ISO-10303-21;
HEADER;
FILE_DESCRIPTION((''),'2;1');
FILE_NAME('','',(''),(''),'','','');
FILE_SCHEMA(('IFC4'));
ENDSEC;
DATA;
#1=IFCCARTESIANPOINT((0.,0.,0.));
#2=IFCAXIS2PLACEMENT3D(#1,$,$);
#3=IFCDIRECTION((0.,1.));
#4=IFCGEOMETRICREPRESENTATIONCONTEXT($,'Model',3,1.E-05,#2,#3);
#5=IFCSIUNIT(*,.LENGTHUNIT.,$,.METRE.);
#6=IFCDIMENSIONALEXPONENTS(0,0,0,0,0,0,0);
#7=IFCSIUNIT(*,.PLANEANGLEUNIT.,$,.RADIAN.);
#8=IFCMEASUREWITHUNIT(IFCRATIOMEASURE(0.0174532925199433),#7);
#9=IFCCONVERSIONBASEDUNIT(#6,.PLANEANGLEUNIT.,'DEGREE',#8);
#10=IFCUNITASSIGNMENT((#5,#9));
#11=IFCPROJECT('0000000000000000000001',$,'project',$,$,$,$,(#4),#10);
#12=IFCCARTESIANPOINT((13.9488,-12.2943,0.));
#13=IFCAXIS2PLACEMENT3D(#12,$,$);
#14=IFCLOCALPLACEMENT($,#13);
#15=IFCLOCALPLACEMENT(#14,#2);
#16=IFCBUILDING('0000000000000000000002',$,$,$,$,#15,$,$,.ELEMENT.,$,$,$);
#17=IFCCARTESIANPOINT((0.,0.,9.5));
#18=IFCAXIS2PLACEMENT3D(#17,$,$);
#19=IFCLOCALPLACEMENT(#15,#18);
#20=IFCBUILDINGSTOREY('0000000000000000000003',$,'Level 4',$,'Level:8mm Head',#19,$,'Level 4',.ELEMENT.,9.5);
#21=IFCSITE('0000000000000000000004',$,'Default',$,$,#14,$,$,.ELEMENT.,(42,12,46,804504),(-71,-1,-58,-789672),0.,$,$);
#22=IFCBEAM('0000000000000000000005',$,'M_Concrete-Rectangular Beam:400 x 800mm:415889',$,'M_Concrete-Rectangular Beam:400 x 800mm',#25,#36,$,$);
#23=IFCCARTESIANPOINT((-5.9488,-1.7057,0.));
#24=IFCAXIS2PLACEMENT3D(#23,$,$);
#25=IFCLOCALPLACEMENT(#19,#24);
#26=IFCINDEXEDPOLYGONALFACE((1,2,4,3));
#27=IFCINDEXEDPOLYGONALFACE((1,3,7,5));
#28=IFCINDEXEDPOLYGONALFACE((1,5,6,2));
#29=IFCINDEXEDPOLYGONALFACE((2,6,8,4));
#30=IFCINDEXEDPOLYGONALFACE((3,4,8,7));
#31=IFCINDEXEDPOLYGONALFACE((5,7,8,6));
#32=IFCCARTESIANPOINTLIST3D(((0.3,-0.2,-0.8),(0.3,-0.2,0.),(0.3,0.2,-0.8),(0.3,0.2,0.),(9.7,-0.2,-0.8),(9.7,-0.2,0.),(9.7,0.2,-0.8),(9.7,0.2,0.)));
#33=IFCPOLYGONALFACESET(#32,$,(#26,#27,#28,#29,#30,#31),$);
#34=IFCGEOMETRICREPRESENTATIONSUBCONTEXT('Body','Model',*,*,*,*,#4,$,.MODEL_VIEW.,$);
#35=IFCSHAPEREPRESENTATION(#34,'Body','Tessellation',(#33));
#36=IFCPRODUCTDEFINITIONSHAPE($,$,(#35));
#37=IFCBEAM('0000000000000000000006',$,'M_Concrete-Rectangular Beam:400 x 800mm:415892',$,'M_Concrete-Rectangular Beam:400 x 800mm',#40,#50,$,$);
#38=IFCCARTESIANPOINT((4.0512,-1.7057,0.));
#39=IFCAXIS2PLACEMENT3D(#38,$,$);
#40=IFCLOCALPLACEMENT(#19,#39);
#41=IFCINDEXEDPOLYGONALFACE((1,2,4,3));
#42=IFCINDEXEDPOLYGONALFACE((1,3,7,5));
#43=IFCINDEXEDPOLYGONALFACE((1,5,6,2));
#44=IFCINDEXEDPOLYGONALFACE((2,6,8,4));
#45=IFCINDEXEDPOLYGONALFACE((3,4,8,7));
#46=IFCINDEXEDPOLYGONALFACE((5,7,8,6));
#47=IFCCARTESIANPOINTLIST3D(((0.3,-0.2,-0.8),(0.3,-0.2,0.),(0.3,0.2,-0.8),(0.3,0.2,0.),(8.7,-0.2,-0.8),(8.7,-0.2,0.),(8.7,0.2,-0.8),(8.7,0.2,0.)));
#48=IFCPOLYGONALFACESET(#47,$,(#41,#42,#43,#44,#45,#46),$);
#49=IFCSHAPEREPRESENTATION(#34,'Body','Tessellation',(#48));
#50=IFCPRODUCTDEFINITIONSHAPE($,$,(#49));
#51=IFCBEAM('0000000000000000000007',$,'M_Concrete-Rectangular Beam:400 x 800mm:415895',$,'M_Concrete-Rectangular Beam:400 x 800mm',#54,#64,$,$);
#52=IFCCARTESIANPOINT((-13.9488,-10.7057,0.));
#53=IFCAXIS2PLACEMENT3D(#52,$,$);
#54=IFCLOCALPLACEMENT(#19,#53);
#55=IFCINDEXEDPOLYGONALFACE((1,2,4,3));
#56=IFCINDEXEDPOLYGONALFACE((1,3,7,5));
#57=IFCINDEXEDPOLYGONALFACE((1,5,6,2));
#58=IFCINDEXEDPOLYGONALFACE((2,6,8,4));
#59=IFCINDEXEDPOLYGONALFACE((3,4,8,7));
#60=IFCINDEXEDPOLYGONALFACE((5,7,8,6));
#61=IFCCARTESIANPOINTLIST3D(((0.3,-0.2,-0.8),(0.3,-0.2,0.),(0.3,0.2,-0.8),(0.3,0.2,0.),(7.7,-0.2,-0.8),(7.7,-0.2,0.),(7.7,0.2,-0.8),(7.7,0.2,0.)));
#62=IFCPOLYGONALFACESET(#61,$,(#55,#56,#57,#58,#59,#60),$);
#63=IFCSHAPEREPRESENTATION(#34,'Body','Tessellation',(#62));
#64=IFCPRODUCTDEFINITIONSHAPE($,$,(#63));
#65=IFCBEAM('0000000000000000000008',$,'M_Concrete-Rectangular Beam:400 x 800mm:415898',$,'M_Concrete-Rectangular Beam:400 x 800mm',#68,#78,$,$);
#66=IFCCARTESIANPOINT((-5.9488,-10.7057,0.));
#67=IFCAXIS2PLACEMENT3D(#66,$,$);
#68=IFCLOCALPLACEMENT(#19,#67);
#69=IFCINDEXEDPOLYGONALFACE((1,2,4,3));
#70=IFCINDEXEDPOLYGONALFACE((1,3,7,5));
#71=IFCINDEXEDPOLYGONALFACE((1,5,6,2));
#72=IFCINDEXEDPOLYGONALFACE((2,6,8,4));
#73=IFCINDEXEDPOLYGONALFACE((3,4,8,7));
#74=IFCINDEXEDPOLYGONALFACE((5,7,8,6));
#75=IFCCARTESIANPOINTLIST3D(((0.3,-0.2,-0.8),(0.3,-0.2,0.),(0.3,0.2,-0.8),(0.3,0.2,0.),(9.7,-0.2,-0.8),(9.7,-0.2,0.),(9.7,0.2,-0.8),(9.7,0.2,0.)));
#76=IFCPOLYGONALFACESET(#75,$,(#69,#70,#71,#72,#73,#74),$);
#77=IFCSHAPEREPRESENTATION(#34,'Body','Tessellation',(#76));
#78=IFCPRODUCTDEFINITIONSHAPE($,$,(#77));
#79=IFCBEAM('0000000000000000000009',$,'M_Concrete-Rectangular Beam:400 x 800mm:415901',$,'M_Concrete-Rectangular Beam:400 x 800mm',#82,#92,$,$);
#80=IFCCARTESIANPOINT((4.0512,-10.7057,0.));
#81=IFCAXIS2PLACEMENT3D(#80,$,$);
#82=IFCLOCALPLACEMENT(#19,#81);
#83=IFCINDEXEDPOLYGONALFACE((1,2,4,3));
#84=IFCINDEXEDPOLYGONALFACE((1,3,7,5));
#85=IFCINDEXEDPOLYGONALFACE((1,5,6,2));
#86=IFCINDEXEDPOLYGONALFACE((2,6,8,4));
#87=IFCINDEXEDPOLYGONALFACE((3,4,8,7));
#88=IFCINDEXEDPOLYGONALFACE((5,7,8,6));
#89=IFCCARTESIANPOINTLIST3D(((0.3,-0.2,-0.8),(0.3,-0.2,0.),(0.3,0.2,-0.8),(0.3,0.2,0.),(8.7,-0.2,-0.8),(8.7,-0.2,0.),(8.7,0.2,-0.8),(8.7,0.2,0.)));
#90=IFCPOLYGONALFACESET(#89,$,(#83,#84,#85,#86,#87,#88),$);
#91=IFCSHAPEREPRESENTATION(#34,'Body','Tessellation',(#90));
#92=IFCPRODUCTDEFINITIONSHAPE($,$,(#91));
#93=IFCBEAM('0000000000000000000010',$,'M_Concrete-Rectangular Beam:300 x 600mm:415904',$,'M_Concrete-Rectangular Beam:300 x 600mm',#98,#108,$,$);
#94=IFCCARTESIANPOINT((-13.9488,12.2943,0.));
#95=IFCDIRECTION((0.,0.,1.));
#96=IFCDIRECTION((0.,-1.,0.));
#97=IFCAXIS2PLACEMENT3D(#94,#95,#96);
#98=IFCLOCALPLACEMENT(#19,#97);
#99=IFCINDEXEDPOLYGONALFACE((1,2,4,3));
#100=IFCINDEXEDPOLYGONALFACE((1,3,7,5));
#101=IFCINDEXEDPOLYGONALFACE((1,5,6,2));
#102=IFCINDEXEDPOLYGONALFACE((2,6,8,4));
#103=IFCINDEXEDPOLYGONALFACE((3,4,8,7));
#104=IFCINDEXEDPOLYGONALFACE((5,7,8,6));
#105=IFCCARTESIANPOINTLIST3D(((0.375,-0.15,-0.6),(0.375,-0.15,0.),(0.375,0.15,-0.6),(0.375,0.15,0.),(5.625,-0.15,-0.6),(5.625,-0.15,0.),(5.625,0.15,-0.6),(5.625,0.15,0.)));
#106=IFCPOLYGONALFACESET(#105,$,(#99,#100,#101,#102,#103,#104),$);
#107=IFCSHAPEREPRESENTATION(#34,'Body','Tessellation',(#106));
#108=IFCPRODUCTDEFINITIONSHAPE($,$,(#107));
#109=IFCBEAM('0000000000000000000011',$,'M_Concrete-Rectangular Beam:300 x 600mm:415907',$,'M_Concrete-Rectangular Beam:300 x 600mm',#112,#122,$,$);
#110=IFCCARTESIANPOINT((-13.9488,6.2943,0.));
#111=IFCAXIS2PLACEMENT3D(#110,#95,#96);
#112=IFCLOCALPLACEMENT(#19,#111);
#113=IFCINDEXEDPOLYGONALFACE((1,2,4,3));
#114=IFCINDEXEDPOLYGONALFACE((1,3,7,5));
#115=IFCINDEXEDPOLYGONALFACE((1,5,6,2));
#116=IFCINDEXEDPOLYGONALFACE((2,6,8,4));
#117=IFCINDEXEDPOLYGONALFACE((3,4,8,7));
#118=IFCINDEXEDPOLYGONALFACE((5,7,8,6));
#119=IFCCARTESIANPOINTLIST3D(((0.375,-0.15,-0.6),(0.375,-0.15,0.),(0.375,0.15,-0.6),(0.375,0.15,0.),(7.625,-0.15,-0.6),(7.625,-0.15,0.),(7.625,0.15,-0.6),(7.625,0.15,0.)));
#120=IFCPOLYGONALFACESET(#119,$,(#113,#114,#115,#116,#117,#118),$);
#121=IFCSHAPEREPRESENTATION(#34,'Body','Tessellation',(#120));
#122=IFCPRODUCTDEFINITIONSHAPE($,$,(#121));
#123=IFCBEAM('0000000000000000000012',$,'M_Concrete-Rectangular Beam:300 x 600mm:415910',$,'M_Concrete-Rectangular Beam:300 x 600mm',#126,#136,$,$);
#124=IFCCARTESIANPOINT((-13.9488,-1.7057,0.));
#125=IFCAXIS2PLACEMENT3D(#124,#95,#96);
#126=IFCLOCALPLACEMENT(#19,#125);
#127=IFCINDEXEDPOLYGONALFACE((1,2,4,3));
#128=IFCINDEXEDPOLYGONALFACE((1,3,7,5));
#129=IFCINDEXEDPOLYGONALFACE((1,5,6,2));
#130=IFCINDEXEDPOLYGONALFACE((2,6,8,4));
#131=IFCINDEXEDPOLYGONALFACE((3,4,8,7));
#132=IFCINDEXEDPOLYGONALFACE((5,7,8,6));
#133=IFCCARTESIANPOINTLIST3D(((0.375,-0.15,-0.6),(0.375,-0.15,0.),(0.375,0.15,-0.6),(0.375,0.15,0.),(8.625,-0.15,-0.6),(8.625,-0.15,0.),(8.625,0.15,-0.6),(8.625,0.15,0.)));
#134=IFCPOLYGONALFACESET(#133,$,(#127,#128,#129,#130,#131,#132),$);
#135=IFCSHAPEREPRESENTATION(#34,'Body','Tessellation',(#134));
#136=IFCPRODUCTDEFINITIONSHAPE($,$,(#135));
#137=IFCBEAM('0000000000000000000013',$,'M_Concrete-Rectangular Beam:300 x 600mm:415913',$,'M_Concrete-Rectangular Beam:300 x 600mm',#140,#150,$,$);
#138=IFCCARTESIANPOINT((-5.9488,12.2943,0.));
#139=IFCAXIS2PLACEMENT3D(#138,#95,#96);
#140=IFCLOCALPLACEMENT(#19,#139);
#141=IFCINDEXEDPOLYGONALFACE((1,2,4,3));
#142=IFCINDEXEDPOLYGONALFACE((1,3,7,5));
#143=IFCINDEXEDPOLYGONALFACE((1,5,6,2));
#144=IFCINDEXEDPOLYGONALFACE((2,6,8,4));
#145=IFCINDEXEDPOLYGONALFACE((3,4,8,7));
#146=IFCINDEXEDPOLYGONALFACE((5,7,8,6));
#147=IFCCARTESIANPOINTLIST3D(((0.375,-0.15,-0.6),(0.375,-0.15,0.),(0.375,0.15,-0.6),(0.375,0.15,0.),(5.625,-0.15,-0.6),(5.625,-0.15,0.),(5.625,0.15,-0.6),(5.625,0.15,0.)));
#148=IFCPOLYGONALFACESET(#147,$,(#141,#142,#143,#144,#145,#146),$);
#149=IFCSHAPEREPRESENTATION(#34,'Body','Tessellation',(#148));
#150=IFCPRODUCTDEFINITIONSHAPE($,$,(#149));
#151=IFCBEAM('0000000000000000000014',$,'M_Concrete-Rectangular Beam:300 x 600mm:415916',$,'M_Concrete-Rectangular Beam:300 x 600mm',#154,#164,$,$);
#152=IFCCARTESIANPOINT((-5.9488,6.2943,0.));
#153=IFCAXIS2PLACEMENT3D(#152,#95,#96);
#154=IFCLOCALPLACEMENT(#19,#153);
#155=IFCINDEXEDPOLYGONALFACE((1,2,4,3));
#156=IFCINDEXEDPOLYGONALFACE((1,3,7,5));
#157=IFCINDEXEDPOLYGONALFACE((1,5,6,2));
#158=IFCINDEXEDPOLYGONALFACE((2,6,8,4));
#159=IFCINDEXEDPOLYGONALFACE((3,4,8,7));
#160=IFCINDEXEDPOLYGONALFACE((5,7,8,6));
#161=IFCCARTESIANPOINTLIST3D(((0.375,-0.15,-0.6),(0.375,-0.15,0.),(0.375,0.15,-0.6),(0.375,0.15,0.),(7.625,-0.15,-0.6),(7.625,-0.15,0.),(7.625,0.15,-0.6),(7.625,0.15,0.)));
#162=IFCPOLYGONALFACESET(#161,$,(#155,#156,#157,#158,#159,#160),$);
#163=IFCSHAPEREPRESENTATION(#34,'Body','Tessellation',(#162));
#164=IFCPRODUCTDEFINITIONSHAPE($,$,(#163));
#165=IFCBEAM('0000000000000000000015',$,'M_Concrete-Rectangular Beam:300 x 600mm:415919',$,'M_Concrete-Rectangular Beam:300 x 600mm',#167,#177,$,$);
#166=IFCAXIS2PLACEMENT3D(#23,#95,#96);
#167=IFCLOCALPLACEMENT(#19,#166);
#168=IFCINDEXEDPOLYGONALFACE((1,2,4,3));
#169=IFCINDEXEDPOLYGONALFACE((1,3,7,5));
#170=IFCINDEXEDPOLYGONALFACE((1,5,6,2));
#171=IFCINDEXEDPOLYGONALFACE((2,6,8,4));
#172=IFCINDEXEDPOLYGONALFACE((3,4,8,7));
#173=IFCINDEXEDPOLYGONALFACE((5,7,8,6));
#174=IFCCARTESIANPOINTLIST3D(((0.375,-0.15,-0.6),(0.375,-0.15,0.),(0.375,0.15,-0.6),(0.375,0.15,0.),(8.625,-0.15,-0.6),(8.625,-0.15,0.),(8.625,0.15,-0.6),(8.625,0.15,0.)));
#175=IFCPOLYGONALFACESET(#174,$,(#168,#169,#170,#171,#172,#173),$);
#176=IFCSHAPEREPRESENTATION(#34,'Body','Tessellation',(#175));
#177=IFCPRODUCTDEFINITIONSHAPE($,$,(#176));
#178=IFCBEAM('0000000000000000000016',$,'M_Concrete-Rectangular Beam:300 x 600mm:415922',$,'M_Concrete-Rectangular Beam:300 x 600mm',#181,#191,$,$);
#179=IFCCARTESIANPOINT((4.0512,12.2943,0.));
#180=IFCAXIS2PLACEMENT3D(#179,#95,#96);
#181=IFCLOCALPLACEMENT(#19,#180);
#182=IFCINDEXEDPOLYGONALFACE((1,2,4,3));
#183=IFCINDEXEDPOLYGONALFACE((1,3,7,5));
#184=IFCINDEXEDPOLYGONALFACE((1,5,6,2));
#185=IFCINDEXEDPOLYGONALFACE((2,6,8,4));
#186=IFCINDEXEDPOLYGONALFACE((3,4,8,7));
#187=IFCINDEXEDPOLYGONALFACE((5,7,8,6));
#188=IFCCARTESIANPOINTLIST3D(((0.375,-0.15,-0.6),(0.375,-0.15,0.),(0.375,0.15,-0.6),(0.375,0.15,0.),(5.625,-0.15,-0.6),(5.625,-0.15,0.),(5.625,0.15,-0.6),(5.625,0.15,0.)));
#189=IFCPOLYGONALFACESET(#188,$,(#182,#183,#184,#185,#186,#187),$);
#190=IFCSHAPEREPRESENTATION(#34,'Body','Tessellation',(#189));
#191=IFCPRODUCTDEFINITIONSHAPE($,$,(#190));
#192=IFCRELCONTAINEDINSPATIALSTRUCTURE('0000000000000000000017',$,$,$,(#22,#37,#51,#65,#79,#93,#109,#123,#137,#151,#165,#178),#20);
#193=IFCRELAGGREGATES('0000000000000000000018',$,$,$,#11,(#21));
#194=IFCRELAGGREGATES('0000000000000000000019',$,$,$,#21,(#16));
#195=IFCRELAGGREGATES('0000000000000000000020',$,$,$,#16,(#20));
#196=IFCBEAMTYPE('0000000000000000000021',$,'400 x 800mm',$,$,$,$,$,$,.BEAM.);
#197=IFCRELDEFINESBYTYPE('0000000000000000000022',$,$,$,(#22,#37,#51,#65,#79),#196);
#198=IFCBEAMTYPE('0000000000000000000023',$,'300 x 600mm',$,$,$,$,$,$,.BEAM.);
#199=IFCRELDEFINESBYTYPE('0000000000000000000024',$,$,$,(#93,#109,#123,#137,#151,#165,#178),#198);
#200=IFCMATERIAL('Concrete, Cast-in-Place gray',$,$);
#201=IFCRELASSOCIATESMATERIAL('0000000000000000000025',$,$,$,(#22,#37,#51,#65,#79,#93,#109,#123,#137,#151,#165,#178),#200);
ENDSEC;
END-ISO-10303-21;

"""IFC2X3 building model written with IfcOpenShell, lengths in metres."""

from ifc_helpers import new_model, entity, si_unit, converted_unit, direction, frame, frame_2d, origin, place, context, subcontext, project, spatial, rectangle, extrude, material, type_object, element, save


model = new_model("IFC2X3")

# Units and contexts
model_context = context("Model", 3, precision=1e-05, world=origin(), true_north=direction((0.0, 1.0)))
body_context = subcontext(model_context, "Body", "Model", "MODEL_VIEW")
ifc_project = project(units=[si_unit("LENGTHUNIT", "METRE"), converted_unit("PLANEANGLEUNIT", "DEGREE", entity("IfcRatioMeasure", 0.0174532925199433), si_unit("PLANEANGLEUNIT", "RADIAN"), dimensions=[0, 0, 0, 0, 0, 0, 0])], contexts=[model_context])

# Site, building, storey
site_placement = place(None, frame((13.9488, -12.2943, 0.0)))
site = spatial("IfcSite", under=ifc_project, at=site_placement, Name="Default", CompositionType="ELEMENT", RefLatitude=(42, 12, 46, 804504), RefLongitude=(-71, -1, -58, -789672), RefElevation=0.0)
building_placement = place(site_placement, origin())
building = spatial("IfcBuilding", under=site, at=building_placement, CompositionType="ELEMENT")
storey_placement = place(building_placement, frame((0.0, 0.0, 9.5)))
storey = spatial("IfcBuildingStorey", under=building, at=storey_placement, Name="Level 4", ObjectType="Level:8mm Head", LongName="Level 4", CompositionType="ELEMENT", Elevation=9.5)

# Shared definitions
ifc_material = material(Name="Concrete, Cast-in-Place gray")

# Beams
beam_type_1 = type_object("IfcBeamType", Name="400 x 800mm", PredefinedType="BEAM")
beam_1_placement = place(storey_placement, frame((-5.9488, -1.7057, 0.0)))
element("IfcBeam", 1, at=beam_1_placement, inside=storey, type_object=beam_type_1, material=ifc_material, Name="M_Concrete-Rectangular Beam:400 x 800mm:415889", ObjectType="M_Concrete-Rectangular Beam:400 x 800mm", context=body_context, shape_type="SweptSolid", body=[
    extrude(rectangle(XDim=0.8, YDim=0.4, at=frame_2d((0.0, 0.0), x_axis=(1.0, 0.0))), frame((0.3, 0.0, -0.4), z_axis=(1.0, 0.0, 0.0), x_axis=(0.0, 0.0, -1.0)), (0.0, 0.0, 1.0), 9.4),
])
beam_2_placement = place(storey_placement, frame((4.0512, -1.7057, 0.0)))
element("IfcBeam", 2, at=beam_2_placement, inside=storey, type_object=beam_type_1, material=ifc_material, Name="M_Concrete-Rectangular Beam:400 x 800mm:415892", ObjectType="M_Concrete-Rectangular Beam:400 x 800mm", context=body_context, shape_type="SweptSolid", body=[
    extrude(rectangle(XDim=0.8, YDim=0.4, at=frame_2d((0.0, 0.0), x_axis=(1.0, 0.0))), frame((0.3, 0.0, -0.4), z_axis=(1.0, 0.0, 0.0), x_axis=(0.0, 0.0, -1.0)), (0.0, 0.0, 1.0), 8.4),
])
beam_3_placement = place(storey_placement, frame((-13.9488, -10.7057, 0.0)))
element("IfcBeam", 3, at=beam_3_placement, inside=storey, type_object=beam_type_1, material=ifc_material, Name="M_Concrete-Rectangular Beam:400 x 800mm:415895", ObjectType="M_Concrete-Rectangular Beam:400 x 800mm", context=body_context, shape_type="SweptSolid", body=[
    extrude(rectangle(XDim=0.8, YDim=0.4, at=frame_2d((0.0, 0.0), x_axis=(1.0, 0.0))), frame((0.3, 0.0, -0.4), z_axis=(1.0, 0.0, 0.0), x_axis=(0.0, 0.0, -1.0)), (0.0, 0.0, 1.0), 7.4),
])
beam_4_placement = place(storey_placement, frame((-5.9488, -10.7057, 0.0)))
element("IfcBeam", 4, at=beam_4_placement, inside=storey, type_object=beam_type_1, material=ifc_material, Name="M_Concrete-Rectangular Beam:400 x 800mm:415898", ObjectType="M_Concrete-Rectangular Beam:400 x 800mm", context=body_context, shape_type="SweptSolid", body=[
    extrude(rectangle(XDim=0.8, YDim=0.4, at=frame_2d((0.0, 0.0), x_axis=(1.0, 0.0))), frame((0.3, 0.0, -0.4), z_axis=(1.0, 0.0, 0.0), x_axis=(0.0, 0.0, -1.0)), (0.0, 0.0, 1.0), 9.4),
])
beam_5_placement = place(storey_placement, frame((4.0512, -10.7057, 0.0)))
element("IfcBeam", 5, at=beam_5_placement, inside=storey, type_object=beam_type_1, material=ifc_material, Name="M_Concrete-Rectangular Beam:400 x 800mm:415901", ObjectType="M_Concrete-Rectangular Beam:400 x 800mm", context=body_context, shape_type="SweptSolid", body=[
    extrude(rectangle(XDim=0.8, YDim=0.4, at=frame_2d((0.0, 0.0), x_axis=(1.0, 0.0))), frame((0.3, 0.0, -0.4), z_axis=(1.0, 0.0, 0.0), x_axis=(0.0, 0.0, -1.0)), (0.0, 0.0, 1.0), 8.4),
])
beam_type_2 = type_object("IfcBeamType", Name="300 x 600mm", PredefinedType="BEAM")
beam_6_placement = place(storey_placement, frame((-13.9488, 12.2943, 0.0), z_axis=(0.0, 0.0, 1.0), x_axis=(0.0, -1.0, 0.0)))
element("IfcBeam", 6, at=beam_6_placement, inside=storey, type_object=beam_type_2, material=ifc_material, Name="M_Concrete-Rectangular Beam:300 x 600mm:415904", ObjectType="M_Concrete-Rectangular Beam:300 x 600mm", context=body_context, shape_type="SweptSolid", body=[
    extrude(rectangle(XDim=0.6, YDim=0.3, at=frame_2d((0.0, 0.0), x_axis=(1.0, 0.0))), frame((0.375, 0.0, -0.3), z_axis=(1.0, 0.0, 0.0), x_axis=(0.0, 0.0, -1.0)), (0.0, 0.0, 1.0), 5.25),
])
beam_7_placement = place(storey_placement, frame((-13.9488, 6.2943, 0.0), z_axis=(0.0, 0.0, 1.0), x_axis=(0.0, -1.0, 0.0)))
element("IfcBeam", 7, at=beam_7_placement, inside=storey, type_object=beam_type_2, material=ifc_material, Name="M_Concrete-Rectangular Beam:300 x 600mm:415907", ObjectType="M_Concrete-Rectangular Beam:300 x 600mm", context=body_context, shape_type="SweptSolid", body=[
    extrude(rectangle(XDim=0.6, YDim=0.3, at=frame_2d((0.0, 0.0), x_axis=(1.0, 0.0))), frame((0.375, 0.0, -0.3), z_axis=(1.0, 0.0, 0.0), x_axis=(0.0, 0.0, -1.0)), (0.0, 0.0, 1.0), 7.25),
])
beam_8_placement = place(storey_placement, frame((-13.9488, -1.7057, 0.0), z_axis=(0.0, 0.0, 1.0), x_axis=(0.0, -1.0, 0.0)))
element("IfcBeam", 8, at=beam_8_placement, inside=storey, type_object=beam_type_2, material=ifc_material, Name="M_Concrete-Rectangular Beam:300 x 600mm:415910", ObjectType="M_Concrete-Rectangular Beam:300 x 600mm", context=body_context, shape_type="SweptSolid", body=[
    extrude(rectangle(XDim=0.6, YDim=0.3, at=frame_2d((0.0, 0.0), x_axis=(1.0, 0.0))), frame((0.375, 0.0, -0.3), z_axis=(1.0, 0.0, 0.0), x_axis=(0.0, 0.0, -1.0)), (0.0, 0.0, 1.0), 8.25),
])
beam_9_placement = place(storey_placement, frame((-5.9488, 12.2943, 0.0), z_axis=(0.0, 0.0, 1.0), x_axis=(0.0, -1.0, 0.0)))
element("IfcBeam", 9, at=beam_9_placement, inside=storey, type_object=beam_type_2, material=ifc_material, Name="M_Concrete-Rectangular Beam:300 x 600mm:415913", ObjectType="M_Concrete-Rectangular Beam:300 x 600mm", context=body_context, shape_type="SweptSolid", body=[
    extrude(rectangle(XDim=0.6, YDim=0.3, at=frame_2d((0.0, 0.0), x_axis=(1.0, 0.0))), frame((0.375, 0.0, -0.3), z_axis=(1.0, 0.0, 0.0), x_axis=(0.0, 0.0, -1.0)), (0.0, 0.0, 1.0), 5.25),
])
beam_10_placement = place(storey_placement, frame((-5.9488, 6.2943, 0.0), z_axis=(0.0, 0.0, 1.0), x_axis=(0.0, -1.0, 0.0)))
element("IfcBeam", 10, at=beam_10_placement, inside=storey, type_object=beam_type_2, material=ifc_material, Name="M_Concrete-Rectangular Beam:300 x 600mm:415916", ObjectType="M_Concrete-Rectangular Beam:300 x 600mm", context=body_context, shape_type="SweptSolid", body=[
    extrude(rectangle(XDim=0.6, YDim=0.3, at=frame_2d((0.0, 0.0), x_axis=(1.0, 0.0))), frame((0.375, 0.0, -0.3), z_axis=(1.0, 0.0, 0.0), x_axis=(0.0, 0.0, -1.0)), (0.0, 0.0, 1.0), 7.25),
])
beam_11_placement = place(storey_placement, frame((-5.9488, -1.7057, 0.0), z_axis=(0.0, 0.0, 1.0), x_axis=(0.0, -1.0, 0.0)))
element("IfcBeam", 11, at=beam_11_placement, inside=storey, type_object=beam_type_2, material=ifc_material, Name="M_Concrete-Rectangular Beam:300 x 600mm:415919", ObjectType="M_Concrete-Rectangular Beam:300 x 600mm", context=body_context, shape_type="SweptSolid", body=[
    extrude(rectangle(XDim=0.6, YDim=0.3, at=frame_2d((0.0, 0.0), x_axis=(1.0, 0.0))), frame((0.375, 0.0, -0.3), z_axis=(1.0, 0.0, 0.0), x_axis=(0.0, 0.0, -1.0)), (0.0, 0.0, 1.0), 8.25),
])
beam_12_placement = place(storey_placement, frame((4.0512, 12.2943, 0.0), z_axis=(0.0, 0.0, 1.0), x_axis=(0.0, -1.0, 0.0)))
element("IfcBeam", 12, at=beam_12_placement, inside=storey, type_object=beam_type_2, material=ifc_material, Name="M_Concrete-Rectangular Beam:300 x 600mm:415922", ObjectType="M_Concrete-Rectangular Beam:300 x 600mm", context=body_context, shape_type="SweptSolid", body=[
    extrude(rectangle(XDim=0.6, YDim=0.3, at=frame_2d((0.0, 0.0), x_axis=(1.0, 0.0))), frame((0.375, 0.0, -0.3), z_axis=(1.0, 0.0, 0.0), x_axis=(0.0, 0.0, -1.0)), (0.0, 0.0, 1.0), 5.25),
])

save(model, "model.ifc")
